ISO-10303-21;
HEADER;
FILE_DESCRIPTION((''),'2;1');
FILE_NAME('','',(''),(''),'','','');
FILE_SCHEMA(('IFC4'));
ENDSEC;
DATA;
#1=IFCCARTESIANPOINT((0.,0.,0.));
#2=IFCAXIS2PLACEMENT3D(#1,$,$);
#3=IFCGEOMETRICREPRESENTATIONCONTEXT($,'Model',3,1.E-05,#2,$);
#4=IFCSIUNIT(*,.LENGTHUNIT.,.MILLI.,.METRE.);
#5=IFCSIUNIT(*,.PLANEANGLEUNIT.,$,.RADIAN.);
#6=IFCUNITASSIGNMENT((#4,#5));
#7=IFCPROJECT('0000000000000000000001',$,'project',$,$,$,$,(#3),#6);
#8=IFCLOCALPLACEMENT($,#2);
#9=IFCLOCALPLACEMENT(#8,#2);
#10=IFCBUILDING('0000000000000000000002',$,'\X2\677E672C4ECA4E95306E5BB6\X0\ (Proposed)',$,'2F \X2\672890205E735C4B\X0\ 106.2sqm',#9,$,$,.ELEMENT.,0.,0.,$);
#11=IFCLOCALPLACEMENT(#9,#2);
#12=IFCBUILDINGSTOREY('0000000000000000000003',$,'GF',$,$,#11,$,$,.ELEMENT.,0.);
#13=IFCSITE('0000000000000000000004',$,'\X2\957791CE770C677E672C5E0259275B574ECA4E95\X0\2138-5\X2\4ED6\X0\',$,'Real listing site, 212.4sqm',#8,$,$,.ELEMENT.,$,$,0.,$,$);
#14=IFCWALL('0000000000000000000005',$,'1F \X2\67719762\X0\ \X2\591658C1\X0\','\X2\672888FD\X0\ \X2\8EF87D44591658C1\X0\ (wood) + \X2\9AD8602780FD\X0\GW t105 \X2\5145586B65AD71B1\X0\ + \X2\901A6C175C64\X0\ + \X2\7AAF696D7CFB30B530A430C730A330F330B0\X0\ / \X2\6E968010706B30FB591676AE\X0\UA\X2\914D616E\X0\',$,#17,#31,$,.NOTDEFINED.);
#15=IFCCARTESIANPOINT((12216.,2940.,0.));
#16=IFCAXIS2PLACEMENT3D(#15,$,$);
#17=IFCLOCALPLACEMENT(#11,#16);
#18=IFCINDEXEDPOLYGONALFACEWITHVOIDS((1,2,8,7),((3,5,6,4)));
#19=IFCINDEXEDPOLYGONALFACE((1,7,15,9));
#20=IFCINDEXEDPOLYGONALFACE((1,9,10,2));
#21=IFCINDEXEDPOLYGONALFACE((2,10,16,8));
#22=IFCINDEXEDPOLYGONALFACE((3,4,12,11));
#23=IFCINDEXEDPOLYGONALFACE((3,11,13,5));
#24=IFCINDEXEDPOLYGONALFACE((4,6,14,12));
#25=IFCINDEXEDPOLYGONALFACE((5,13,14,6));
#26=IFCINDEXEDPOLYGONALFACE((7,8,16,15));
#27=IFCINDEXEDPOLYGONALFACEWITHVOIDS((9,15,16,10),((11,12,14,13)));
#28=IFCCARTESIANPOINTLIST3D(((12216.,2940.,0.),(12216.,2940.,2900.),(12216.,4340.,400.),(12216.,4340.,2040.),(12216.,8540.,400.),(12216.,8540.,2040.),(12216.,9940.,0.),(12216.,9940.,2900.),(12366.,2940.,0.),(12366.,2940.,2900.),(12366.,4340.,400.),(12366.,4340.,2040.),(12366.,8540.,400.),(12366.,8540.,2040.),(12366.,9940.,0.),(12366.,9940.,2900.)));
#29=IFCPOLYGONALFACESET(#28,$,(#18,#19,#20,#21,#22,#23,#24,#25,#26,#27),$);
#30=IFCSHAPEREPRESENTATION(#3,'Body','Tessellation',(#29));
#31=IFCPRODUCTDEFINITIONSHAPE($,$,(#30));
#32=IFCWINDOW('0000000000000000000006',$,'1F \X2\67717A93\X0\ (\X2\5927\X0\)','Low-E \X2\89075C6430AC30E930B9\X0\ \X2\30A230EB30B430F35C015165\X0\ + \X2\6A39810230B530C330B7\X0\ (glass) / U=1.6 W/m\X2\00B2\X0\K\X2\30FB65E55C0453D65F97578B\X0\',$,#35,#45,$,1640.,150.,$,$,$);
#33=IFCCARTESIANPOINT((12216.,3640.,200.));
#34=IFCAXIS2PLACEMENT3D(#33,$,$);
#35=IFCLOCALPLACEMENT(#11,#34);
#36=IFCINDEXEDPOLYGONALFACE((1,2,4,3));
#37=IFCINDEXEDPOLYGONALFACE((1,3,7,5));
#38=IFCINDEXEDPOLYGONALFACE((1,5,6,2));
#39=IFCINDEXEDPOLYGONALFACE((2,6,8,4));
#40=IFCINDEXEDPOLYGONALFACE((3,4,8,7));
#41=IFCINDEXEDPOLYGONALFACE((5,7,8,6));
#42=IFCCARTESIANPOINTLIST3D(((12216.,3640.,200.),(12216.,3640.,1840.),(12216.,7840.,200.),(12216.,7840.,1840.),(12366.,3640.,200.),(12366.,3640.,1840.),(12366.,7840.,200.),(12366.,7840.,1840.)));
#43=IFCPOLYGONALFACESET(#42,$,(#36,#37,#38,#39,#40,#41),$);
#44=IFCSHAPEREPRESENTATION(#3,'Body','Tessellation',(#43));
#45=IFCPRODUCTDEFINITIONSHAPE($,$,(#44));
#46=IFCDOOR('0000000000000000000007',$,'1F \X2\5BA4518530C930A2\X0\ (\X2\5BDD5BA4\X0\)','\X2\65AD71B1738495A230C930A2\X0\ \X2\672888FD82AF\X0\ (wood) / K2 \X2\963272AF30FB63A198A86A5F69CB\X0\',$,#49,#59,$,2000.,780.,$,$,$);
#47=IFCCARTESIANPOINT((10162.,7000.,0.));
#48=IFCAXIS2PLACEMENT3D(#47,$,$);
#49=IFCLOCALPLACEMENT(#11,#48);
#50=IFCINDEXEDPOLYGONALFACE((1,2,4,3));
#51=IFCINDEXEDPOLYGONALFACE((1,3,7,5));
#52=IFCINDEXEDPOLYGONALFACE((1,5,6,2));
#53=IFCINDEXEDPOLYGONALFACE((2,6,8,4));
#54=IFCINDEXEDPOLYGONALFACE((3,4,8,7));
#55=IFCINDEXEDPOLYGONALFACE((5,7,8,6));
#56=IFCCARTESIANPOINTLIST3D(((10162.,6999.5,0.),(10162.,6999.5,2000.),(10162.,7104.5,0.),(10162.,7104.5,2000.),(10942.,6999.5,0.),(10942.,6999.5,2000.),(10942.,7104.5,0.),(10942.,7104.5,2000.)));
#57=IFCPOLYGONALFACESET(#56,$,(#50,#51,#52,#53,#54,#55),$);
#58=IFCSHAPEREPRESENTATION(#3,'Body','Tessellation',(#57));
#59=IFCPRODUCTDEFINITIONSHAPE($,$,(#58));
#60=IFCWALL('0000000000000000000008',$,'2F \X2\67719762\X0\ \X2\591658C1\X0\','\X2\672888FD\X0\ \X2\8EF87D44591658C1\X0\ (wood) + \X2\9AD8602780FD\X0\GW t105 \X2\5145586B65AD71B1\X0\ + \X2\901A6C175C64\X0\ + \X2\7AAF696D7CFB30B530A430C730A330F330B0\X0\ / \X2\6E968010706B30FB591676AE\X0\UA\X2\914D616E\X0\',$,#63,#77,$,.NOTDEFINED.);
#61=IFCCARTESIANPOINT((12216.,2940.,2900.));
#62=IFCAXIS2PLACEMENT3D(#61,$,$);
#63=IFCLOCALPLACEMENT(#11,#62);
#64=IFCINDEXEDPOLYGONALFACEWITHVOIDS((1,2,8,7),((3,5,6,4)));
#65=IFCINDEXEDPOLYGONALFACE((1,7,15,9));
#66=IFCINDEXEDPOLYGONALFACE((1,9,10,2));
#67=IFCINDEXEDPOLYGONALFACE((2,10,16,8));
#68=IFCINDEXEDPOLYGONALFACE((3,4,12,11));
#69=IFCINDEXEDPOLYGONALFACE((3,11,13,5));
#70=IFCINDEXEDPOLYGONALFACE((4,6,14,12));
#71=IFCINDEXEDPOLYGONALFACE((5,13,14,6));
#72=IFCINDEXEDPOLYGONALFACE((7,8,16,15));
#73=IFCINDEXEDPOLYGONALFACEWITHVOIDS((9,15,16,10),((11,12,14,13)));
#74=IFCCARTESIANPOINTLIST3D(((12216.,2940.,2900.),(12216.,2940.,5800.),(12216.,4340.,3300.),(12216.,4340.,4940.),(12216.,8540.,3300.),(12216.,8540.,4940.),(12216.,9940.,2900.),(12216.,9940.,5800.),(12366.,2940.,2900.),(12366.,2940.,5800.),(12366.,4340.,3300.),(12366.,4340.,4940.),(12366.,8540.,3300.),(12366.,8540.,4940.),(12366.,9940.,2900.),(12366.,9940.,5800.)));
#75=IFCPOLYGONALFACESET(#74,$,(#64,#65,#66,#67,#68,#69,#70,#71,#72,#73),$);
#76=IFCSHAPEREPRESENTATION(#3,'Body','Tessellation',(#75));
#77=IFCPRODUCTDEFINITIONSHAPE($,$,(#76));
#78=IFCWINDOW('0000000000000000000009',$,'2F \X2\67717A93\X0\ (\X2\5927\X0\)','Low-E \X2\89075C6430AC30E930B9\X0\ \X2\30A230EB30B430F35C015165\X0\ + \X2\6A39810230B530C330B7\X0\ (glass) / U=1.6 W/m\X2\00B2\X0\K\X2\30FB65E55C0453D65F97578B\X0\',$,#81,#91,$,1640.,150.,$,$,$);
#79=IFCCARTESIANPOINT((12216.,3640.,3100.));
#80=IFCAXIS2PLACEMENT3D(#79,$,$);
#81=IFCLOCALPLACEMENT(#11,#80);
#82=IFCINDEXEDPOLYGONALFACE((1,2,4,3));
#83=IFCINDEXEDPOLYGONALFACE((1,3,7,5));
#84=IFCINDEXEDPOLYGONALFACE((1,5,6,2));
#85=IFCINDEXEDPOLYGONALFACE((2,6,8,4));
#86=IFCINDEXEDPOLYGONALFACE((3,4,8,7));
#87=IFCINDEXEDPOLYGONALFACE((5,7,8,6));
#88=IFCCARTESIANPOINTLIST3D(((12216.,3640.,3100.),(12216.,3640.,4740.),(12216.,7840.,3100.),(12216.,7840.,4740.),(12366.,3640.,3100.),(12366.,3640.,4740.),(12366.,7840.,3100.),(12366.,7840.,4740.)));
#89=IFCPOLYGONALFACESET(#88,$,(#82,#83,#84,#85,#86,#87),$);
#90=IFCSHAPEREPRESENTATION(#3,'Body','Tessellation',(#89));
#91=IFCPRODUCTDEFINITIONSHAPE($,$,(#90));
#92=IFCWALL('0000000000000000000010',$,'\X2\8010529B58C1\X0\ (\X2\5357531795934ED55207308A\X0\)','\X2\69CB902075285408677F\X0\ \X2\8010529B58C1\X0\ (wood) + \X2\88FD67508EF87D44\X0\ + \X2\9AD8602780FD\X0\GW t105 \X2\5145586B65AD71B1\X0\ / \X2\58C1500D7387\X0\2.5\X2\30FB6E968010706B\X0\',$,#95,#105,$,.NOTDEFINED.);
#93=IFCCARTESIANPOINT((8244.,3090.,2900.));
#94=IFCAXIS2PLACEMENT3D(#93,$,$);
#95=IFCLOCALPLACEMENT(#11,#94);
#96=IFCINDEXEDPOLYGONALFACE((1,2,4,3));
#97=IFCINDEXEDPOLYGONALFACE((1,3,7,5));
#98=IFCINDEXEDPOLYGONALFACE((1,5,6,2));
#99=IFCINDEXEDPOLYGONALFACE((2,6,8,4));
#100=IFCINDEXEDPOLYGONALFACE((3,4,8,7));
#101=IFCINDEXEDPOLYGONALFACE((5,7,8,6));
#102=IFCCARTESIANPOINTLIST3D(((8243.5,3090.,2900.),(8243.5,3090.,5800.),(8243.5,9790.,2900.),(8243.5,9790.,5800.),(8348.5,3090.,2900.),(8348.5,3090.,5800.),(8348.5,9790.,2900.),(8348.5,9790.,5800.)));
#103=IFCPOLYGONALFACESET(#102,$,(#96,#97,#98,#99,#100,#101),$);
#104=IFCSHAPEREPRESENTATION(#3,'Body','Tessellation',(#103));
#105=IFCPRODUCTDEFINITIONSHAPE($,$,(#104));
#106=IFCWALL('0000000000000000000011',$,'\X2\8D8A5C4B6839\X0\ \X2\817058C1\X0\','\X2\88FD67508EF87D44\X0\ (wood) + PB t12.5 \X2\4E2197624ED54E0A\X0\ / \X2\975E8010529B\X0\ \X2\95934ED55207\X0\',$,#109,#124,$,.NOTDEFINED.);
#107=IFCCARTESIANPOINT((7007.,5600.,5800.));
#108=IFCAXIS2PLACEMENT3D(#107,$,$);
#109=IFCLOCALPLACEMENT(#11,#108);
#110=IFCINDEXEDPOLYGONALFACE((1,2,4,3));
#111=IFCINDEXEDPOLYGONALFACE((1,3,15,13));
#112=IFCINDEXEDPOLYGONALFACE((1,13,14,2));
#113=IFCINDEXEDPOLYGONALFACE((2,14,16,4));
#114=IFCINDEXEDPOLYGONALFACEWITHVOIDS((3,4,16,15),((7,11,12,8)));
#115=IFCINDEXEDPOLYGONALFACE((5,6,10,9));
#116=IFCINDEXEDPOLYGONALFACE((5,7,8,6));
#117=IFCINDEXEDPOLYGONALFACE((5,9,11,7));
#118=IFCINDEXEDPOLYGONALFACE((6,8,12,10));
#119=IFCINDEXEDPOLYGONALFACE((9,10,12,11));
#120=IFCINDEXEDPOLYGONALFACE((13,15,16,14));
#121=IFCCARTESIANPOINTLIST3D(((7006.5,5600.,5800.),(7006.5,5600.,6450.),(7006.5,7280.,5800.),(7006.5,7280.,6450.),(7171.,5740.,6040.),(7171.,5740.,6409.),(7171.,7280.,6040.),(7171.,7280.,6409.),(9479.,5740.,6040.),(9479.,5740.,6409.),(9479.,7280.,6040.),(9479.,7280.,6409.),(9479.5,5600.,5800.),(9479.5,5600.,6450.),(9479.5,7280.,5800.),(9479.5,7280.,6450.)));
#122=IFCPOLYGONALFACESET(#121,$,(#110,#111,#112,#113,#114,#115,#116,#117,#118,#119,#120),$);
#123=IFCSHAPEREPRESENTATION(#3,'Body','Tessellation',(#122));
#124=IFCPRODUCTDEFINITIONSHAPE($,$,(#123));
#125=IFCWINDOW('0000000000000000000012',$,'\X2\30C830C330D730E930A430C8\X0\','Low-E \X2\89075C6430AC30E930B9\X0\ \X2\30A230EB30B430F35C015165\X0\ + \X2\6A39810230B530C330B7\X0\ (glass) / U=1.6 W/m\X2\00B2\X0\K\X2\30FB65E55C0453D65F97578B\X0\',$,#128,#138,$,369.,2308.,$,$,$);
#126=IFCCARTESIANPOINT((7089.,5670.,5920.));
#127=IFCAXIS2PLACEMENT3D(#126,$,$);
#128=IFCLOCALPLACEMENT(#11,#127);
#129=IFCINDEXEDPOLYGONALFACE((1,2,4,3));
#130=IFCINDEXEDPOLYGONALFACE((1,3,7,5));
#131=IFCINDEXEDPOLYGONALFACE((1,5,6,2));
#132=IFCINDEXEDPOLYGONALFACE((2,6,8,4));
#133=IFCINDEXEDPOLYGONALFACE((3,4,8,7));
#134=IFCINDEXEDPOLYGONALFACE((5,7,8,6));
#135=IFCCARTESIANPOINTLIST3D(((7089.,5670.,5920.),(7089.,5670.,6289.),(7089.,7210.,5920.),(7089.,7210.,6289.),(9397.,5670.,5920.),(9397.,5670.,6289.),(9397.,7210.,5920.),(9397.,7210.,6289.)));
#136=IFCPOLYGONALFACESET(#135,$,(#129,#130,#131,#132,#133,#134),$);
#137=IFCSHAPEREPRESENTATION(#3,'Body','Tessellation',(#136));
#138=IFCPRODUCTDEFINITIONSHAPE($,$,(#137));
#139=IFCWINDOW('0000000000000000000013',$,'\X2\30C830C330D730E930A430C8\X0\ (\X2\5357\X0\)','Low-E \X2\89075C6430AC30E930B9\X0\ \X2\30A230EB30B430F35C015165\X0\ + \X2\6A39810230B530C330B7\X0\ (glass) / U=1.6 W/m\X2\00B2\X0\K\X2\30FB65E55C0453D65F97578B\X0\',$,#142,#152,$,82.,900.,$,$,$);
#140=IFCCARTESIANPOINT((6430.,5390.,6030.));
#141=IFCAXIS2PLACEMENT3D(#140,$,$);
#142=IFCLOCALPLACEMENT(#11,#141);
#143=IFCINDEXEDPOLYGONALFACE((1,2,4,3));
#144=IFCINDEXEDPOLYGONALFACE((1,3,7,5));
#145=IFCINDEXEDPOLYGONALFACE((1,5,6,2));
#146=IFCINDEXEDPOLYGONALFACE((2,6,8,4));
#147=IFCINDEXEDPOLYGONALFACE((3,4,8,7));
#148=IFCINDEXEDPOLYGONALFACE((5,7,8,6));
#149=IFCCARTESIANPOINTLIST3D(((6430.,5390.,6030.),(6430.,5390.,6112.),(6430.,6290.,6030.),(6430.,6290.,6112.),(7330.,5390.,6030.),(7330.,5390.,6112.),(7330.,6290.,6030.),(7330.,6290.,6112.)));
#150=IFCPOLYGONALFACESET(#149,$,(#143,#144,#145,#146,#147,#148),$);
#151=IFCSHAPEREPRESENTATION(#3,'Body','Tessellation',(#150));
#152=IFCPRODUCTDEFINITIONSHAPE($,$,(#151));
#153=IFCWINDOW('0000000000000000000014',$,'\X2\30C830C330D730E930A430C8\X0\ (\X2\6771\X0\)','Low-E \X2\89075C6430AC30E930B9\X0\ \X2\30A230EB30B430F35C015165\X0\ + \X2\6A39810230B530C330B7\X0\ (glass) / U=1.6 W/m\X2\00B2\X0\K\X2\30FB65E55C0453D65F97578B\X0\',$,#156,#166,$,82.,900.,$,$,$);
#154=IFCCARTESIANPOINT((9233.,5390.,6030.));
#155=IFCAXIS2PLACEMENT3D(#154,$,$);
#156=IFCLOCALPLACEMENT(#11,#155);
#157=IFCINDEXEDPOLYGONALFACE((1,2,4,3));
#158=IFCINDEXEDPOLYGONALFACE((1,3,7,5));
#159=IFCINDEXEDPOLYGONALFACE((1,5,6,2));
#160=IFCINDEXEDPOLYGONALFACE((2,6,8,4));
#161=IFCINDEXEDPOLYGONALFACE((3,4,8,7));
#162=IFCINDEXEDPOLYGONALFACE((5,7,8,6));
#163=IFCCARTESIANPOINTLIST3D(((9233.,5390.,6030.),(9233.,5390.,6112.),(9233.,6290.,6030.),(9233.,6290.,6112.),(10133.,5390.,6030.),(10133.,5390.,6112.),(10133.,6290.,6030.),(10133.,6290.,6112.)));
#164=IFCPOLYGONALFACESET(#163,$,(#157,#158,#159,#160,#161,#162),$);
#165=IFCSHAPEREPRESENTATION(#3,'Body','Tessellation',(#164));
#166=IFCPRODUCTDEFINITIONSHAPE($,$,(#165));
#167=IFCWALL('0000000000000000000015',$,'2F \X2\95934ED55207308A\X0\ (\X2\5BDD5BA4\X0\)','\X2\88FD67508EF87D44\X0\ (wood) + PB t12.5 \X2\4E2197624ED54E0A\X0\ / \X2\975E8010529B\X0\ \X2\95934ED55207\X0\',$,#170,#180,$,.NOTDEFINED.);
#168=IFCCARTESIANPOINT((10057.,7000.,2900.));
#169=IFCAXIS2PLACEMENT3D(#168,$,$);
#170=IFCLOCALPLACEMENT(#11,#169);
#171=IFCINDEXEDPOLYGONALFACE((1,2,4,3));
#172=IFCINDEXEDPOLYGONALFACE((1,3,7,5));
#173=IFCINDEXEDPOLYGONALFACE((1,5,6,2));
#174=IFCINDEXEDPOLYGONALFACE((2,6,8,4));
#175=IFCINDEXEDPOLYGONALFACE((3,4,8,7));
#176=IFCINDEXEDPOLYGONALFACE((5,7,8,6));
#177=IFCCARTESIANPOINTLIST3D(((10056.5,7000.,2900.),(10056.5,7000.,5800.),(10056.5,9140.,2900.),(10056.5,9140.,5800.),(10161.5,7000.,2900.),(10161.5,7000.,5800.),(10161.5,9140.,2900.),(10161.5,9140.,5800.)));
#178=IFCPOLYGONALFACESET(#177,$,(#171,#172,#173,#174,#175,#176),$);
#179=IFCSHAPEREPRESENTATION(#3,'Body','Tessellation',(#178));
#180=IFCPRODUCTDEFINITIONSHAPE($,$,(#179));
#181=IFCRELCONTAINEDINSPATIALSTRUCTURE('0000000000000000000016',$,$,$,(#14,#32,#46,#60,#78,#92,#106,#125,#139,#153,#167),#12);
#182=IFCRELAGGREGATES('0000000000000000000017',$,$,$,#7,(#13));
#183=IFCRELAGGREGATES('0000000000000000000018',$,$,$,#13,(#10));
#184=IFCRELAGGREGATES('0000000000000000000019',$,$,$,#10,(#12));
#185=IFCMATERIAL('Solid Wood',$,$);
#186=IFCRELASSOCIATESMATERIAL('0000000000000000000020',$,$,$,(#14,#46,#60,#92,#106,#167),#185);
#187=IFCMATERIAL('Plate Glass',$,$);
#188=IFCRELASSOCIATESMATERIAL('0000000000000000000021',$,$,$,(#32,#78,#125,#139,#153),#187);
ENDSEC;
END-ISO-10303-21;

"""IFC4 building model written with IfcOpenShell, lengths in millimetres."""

from ifc_helpers import new_model, si_unit, frame, frame_2d, origin, place, context, project, spatial, rectangle, extrude, material, element, fill, save


model = new_model("IFC4")

# Units and contexts
model_context = context("Model", 3, precision=1e-05, world=origin())
ifc_project = project(units=[si_unit("LENGTHUNIT", "METRE", prefix="MILLI"), si_unit("PLANEANGLEUNIT", "RADIAN")], contexts=[model_context])

# Site, building, storey
site_placement = place(None, origin())
site = spatial("IfcSite", under=ifc_project, at=site_placement, Name="長野県松本市大字今井2138-5他", ObjectType="Real listing site, 212.4sqm", CompositionType="ELEMENT", RefElevation=0.0)
building_placement = place(site_placement, origin())
building = spatial("IfcBuilding", under=site, at=building_placement, Name="松本今井の家 (Proposed)", ObjectType="2F 木造平屋 106.2sqm", CompositionType="ELEMENT", ElevationOfRefHeight=0.0, ElevationOfTerrain=0.0)
storey_placement = place(building_placement, origin())
storey = spatial("IfcBuildingStorey", under=building, at=storey_placement, Name="GF", CompositionType="ELEMENT", Elevation=0.0)

# Wall, opening, window
ifc_material_1 = material(Name="Solid Wood")
wall_1_placement = place(storey_placement, frame((12216.0, 2940.0, 0.0)))
wall_1 = element("IfcWall", 1, at=wall_1_placement, inside=storey, material=ifc_material_1, Name="1F 東面 外壁", Description="木製 軸組外壁 (wood) + 高性能GW t105 充填断熱 + 通気層 + 窯業系サイディング / 準耐火・外皮UA配慮", PredefinedType="NOTDEFINED", context=model_context, shape_type="SweptSolid", body=[
    extrude(rectangle(XDim=150.0, YDim=7000.0, at=frame_2d((75.0, 3500.0))), frame((12216.0, 2940.0, 0.0)), (0.0, 0.0, 1.0), 2900.0),
])
opening_1_placement = place(storey_placement, frame((12216.0, 3640.0, 200.0)))
opening_1 = element("IfcOpeningElement", 2, at=opening_1_placement, cuts=wall_1, PredefinedType="NOTDEFINED", context=model_context, shape_type="SweptSolid", body=[
    extrude(rectangle(XDim=150.0, YDim=4200.0, at=frame_2d((75.0, 2100.0))), frame((12216.0, 3640.0, 200.0)), (0.0, 0.0, 1.0), 1640.0),
])
ifc_material_2 = material(Name="Plate Glass")
window_1_placement = place(storey_placement, frame((12216.0, 3640.0, 200.0)))
window_1 = element("IfcWindow", 3, at=window_1_placement, inside=storey, material=ifc_material_2, Name="1F 東窓 (大)", Description="Low-E 複層ガラス アルゴン封入 + 樹脂サッシ (glass) / U=1.6 W/m²K・日射取得型", OverallHeight=1640.0, OverallWidth=150.0, context=model_context, shape_type="SweptSolid", body=[
    extrude(rectangle(XDim=150.0, YDim=4200.0, at=frame_2d((75.0, 2100.0))), frame((12216.0, 3640.0, 200.0)), (0.0, 0.0, 1.0), 1640.0),
])
fill(opening_1, window_1)

# Door
door_1_placement = place(storey_placement, frame((10162.0, 7000.0, 0.0)))
element("IfcDoor", 4, at=door_1_placement, inside=storey, material=ifc_material_1, Name="1F 室内ドア (寝室)", Description="断熱玄関ドア 木製芯 (wood) / K2 防犯・採風機構", OverallHeight=2000.0, OverallWidth=780.0, context=model_context, shape_type="SweptSolid", body=[
    extrude(rectangle(XDim=780.0, YDim=105.0, at=frame_2d((390.0, 52.0))), frame((10162.0, 7000.0, 0.0)), (0.0, 0.0, 1.0), 2000.0),
])

# Wall, opening, window
wall_2_placement = place(storey_placement, frame((12216.0, 2940.0, 2900.0)))
wall_2 = element("IfcWall", 5, at=wall_2_placement, inside=storey, material=ifc_material_1, Name="2F 東面 外壁", Description="木製 軸組外壁 (wood) + 高性能GW t105 充填断熱 + 通気層 + 窯業系サイディング / 準耐火・外皮UA配慮", PredefinedType="NOTDEFINED", context=model_context, shape_type="SweptSolid", body=[
    extrude(rectangle(XDim=150.0, YDim=7000.0, at=frame_2d((75.0, 3500.0))), frame((12216.0, 2940.0, 2900.0)), (0.0, 0.0, 1.0), 2900.0),
])
opening_2_placement = place(storey_placement, frame((12216.0, 3640.0, 3100.0)))
opening_2 = element("IfcOpeningElement", 6, at=opening_2_placement, cuts=wall_2, PredefinedType="NOTDEFINED", context=model_context, shape_type="SweptSolid", body=[
    extrude(rectangle(XDim=150.0, YDim=4200.0, at=frame_2d((75.0, 2100.0))), frame((12216.0, 3640.0, 3100.0)), (0.0, 0.0, 1.0), 1640.0),
])
window_2_placement = place(storey_placement, frame((12216.0, 3640.0, 3100.0)))
window_2 = element("IfcWindow", 7, at=window_2_placement, inside=storey, material=ifc_material_2, Name="2F 東窓 (大)", Description="Low-E 複層ガラス アルゴン封入 + 樹脂サッシ (glass) / U=1.6 W/m²K・日射取得型", OverallHeight=1640.0, OverallWidth=150.0, context=model_context, shape_type="SweptSolid", body=[
    extrude(rectangle(XDim=150.0, YDim=4200.0, at=frame_2d((75.0, 2100.0))), frame((12216.0, 3640.0, 3100.0)), (0.0, 0.0, 1.0), 1640.0),
])
fill(opening_2, window_2)

# Wall
wall_3_placement = place(storey_placement, frame((8244.0, 3090.0, 2900.0)))
element("IfcWall", 8, at=wall_3_placement, inside=storey, material=ifc_material_1, Name="耐力壁 (南北間仕切り)", Description="構造用合板 耐力壁 (wood) + 製材軸組 + 高性能GW t105 充填断熱 / 壁倍率2.5・準耐火", PredefinedType="NOTDEFINED", context=model_context, shape_type="SweptSolid", body=[
    extrude(rectangle(XDim=105.0, YDim=6700.0, at=frame_2d((52.0, 3350.0))), frame((8244.0, 3090.0, 2900.0)), (0.0, 0.0, 1.0), 2900.0),
])

# Wall, openings, windows
wall_4_placement = place(storey_placement, frame((7007.0, 5600.0, 5800.0)))
wall_4 = element("IfcWall", 9, at=wall_4_placement, inside=storey, material=ifc_material_1, Name="越屋根 腰壁", Description="製材軸組 (wood) + PB t12.5 両面仕上 / 非耐力 間仕切", PredefinedType="NOTDEFINED", context=model_context, shape_type="SweptSolid", body=[
    extrude(rectangle(XDim=2473.0, YDim=1680.0, at=frame_2d((1236.0, 840.0))), frame((7007.0, 5600.0, 5800.0)), (0.0, 0.0, 1.0), 650.0),
])
opening_3_placement = place(storey_placement, frame((7089.0, 5670.0, 5920.0)))
opening_3 = element("IfcOpeningElement", 10, at=opening_3_placement, cuts=wall_4, PredefinedType="NOTDEFINED", context=model_context, shape_type="SweptSolid", body=[
    extrude(rectangle(XDim=2308.0, YDim=1540.0, at=frame_2d((1154.0, 770.0))), frame((7089.0, 5670.0, 5920.0)), (0.0, 0.0, 1.0), 369.0),
])
opening_4_placement = place(storey_placement, frame((6430.0, 5390.0, 6030.0)))
opening_4 = element("IfcOpeningElement", 11, at=opening_4_placement, cuts=wall_4, PredefinedType="NOTDEFINED", context=model_context, shape_type="SweptSolid", body=[
    extrude(rectangle(XDim=900.0, YDim=900.0, at=frame_2d((450.0, 450.0))), frame((6430.0, 5390.0, 6030.0)), (0.0, 0.0, 1.0), 82.0),
])
opening_5_placement = place(storey_placement, frame((9233.0, 5390.0, 6030.0)))
opening_5 = element("IfcOpeningElement", 12, at=opening_5_placement, cuts=wall_4, PredefinedType="NOTDEFINED", context=model_context, shape_type="SweptSolid", body=[
    extrude(rectangle(XDim=900.0, YDim=900.0, at=frame_2d((450.0, 450.0))), frame((9233.0, 5390.0, 6030.0)), (0.0, 0.0, 1.0), 82.0),
])
window_3_placement = place(storey_placement, frame((7089.0, 5670.0, 5920.0)))
window_3 = element("IfcWindow", 13, at=window_3_placement, inside=storey, material=ifc_material_2, Name="トップライト", Description="Low-E 複層ガラス アルゴン封入 + 樹脂サッシ (glass) / U=1.6 W/m²K・日射取得型", OverallHeight=369.0, OverallWidth=2308.0, context=model_context, shape_type="SweptSolid", body=[
    extrude(rectangle(XDim=2308.0, YDim=1540.0, at=frame_2d((1154.0, 770.0))), frame((7089.0, 5670.0, 5920.0)), (0.0, 0.0, 1.0), 369.0),
])
fill(opening_3, window_3)
window_4_placement = place(storey_placement, frame((6430.0, 5390.0, 6030.0)))
window_4 = element("IfcWindow", 14, at=window_4_placement, inside=storey, material=ifc_material_2, Name="トップライト (南)", Description="Low-E 複層ガラス アルゴン封入 + 樹脂サッシ (glass) / U=1.6 W/m²K・日射取得型", OverallHeight=82.0, OverallWidth=900.0, context=model_context, shape_type="SweptSolid", body=[
    extrude(rectangle(XDim=900.0, YDim=900.0, at=frame_2d((450.0, 450.0))), frame((6430.0, 5390.0, 6030.0)), (0.0, 0.0, 1.0), 82.0),
])
fill(opening_4, window_4)
window_5_placement = place(storey_placement, frame((9233.0, 5390.0, 6030.0)))
window_5 = element("IfcWindow", 15, at=window_5_placement, inside=storey, material=ifc_material_2, Name="トップライト (東)", Description="Low-E 複層ガラス アルゴン封入 + 樹脂サッシ (glass) / U=1.6 W/m²K・日射取得型", OverallHeight=82.0, OverallWidth=900.0, context=model_context, shape_type="SweptSolid", body=[
    extrude(rectangle(XDim=900.0, YDim=900.0, at=frame_2d((450.0, 450.0))), frame((9233.0, 5390.0, 6030.0)), (0.0, 0.0, 1.0), 82.0),
])
fill(opening_5, window_5)

# Wall
wall_5_placement = place(storey_placement, frame((10057.0, 7000.0, 2900.0)))
element("IfcWall", 16, at=wall_5_placement, inside=storey, material=ifc_material_1, Name="2F 間仕切り (寝室)", Description="製材軸組 (wood) + PB t12.5 両面仕上 / 非耐力 間仕切", PredefinedType="NOTDEFINED", context=model_context, shape_type="SweptSolid", body=[
    extrude(rectangle(XDim=105.0, YDim=2140.0, at=frame_2d((52.0, 1070.0))), frame((10057.0, 7000.0, 2900.0)), (0.0, 0.0, 1.0), 2900.0),
])

save(model, "model.ifc")
